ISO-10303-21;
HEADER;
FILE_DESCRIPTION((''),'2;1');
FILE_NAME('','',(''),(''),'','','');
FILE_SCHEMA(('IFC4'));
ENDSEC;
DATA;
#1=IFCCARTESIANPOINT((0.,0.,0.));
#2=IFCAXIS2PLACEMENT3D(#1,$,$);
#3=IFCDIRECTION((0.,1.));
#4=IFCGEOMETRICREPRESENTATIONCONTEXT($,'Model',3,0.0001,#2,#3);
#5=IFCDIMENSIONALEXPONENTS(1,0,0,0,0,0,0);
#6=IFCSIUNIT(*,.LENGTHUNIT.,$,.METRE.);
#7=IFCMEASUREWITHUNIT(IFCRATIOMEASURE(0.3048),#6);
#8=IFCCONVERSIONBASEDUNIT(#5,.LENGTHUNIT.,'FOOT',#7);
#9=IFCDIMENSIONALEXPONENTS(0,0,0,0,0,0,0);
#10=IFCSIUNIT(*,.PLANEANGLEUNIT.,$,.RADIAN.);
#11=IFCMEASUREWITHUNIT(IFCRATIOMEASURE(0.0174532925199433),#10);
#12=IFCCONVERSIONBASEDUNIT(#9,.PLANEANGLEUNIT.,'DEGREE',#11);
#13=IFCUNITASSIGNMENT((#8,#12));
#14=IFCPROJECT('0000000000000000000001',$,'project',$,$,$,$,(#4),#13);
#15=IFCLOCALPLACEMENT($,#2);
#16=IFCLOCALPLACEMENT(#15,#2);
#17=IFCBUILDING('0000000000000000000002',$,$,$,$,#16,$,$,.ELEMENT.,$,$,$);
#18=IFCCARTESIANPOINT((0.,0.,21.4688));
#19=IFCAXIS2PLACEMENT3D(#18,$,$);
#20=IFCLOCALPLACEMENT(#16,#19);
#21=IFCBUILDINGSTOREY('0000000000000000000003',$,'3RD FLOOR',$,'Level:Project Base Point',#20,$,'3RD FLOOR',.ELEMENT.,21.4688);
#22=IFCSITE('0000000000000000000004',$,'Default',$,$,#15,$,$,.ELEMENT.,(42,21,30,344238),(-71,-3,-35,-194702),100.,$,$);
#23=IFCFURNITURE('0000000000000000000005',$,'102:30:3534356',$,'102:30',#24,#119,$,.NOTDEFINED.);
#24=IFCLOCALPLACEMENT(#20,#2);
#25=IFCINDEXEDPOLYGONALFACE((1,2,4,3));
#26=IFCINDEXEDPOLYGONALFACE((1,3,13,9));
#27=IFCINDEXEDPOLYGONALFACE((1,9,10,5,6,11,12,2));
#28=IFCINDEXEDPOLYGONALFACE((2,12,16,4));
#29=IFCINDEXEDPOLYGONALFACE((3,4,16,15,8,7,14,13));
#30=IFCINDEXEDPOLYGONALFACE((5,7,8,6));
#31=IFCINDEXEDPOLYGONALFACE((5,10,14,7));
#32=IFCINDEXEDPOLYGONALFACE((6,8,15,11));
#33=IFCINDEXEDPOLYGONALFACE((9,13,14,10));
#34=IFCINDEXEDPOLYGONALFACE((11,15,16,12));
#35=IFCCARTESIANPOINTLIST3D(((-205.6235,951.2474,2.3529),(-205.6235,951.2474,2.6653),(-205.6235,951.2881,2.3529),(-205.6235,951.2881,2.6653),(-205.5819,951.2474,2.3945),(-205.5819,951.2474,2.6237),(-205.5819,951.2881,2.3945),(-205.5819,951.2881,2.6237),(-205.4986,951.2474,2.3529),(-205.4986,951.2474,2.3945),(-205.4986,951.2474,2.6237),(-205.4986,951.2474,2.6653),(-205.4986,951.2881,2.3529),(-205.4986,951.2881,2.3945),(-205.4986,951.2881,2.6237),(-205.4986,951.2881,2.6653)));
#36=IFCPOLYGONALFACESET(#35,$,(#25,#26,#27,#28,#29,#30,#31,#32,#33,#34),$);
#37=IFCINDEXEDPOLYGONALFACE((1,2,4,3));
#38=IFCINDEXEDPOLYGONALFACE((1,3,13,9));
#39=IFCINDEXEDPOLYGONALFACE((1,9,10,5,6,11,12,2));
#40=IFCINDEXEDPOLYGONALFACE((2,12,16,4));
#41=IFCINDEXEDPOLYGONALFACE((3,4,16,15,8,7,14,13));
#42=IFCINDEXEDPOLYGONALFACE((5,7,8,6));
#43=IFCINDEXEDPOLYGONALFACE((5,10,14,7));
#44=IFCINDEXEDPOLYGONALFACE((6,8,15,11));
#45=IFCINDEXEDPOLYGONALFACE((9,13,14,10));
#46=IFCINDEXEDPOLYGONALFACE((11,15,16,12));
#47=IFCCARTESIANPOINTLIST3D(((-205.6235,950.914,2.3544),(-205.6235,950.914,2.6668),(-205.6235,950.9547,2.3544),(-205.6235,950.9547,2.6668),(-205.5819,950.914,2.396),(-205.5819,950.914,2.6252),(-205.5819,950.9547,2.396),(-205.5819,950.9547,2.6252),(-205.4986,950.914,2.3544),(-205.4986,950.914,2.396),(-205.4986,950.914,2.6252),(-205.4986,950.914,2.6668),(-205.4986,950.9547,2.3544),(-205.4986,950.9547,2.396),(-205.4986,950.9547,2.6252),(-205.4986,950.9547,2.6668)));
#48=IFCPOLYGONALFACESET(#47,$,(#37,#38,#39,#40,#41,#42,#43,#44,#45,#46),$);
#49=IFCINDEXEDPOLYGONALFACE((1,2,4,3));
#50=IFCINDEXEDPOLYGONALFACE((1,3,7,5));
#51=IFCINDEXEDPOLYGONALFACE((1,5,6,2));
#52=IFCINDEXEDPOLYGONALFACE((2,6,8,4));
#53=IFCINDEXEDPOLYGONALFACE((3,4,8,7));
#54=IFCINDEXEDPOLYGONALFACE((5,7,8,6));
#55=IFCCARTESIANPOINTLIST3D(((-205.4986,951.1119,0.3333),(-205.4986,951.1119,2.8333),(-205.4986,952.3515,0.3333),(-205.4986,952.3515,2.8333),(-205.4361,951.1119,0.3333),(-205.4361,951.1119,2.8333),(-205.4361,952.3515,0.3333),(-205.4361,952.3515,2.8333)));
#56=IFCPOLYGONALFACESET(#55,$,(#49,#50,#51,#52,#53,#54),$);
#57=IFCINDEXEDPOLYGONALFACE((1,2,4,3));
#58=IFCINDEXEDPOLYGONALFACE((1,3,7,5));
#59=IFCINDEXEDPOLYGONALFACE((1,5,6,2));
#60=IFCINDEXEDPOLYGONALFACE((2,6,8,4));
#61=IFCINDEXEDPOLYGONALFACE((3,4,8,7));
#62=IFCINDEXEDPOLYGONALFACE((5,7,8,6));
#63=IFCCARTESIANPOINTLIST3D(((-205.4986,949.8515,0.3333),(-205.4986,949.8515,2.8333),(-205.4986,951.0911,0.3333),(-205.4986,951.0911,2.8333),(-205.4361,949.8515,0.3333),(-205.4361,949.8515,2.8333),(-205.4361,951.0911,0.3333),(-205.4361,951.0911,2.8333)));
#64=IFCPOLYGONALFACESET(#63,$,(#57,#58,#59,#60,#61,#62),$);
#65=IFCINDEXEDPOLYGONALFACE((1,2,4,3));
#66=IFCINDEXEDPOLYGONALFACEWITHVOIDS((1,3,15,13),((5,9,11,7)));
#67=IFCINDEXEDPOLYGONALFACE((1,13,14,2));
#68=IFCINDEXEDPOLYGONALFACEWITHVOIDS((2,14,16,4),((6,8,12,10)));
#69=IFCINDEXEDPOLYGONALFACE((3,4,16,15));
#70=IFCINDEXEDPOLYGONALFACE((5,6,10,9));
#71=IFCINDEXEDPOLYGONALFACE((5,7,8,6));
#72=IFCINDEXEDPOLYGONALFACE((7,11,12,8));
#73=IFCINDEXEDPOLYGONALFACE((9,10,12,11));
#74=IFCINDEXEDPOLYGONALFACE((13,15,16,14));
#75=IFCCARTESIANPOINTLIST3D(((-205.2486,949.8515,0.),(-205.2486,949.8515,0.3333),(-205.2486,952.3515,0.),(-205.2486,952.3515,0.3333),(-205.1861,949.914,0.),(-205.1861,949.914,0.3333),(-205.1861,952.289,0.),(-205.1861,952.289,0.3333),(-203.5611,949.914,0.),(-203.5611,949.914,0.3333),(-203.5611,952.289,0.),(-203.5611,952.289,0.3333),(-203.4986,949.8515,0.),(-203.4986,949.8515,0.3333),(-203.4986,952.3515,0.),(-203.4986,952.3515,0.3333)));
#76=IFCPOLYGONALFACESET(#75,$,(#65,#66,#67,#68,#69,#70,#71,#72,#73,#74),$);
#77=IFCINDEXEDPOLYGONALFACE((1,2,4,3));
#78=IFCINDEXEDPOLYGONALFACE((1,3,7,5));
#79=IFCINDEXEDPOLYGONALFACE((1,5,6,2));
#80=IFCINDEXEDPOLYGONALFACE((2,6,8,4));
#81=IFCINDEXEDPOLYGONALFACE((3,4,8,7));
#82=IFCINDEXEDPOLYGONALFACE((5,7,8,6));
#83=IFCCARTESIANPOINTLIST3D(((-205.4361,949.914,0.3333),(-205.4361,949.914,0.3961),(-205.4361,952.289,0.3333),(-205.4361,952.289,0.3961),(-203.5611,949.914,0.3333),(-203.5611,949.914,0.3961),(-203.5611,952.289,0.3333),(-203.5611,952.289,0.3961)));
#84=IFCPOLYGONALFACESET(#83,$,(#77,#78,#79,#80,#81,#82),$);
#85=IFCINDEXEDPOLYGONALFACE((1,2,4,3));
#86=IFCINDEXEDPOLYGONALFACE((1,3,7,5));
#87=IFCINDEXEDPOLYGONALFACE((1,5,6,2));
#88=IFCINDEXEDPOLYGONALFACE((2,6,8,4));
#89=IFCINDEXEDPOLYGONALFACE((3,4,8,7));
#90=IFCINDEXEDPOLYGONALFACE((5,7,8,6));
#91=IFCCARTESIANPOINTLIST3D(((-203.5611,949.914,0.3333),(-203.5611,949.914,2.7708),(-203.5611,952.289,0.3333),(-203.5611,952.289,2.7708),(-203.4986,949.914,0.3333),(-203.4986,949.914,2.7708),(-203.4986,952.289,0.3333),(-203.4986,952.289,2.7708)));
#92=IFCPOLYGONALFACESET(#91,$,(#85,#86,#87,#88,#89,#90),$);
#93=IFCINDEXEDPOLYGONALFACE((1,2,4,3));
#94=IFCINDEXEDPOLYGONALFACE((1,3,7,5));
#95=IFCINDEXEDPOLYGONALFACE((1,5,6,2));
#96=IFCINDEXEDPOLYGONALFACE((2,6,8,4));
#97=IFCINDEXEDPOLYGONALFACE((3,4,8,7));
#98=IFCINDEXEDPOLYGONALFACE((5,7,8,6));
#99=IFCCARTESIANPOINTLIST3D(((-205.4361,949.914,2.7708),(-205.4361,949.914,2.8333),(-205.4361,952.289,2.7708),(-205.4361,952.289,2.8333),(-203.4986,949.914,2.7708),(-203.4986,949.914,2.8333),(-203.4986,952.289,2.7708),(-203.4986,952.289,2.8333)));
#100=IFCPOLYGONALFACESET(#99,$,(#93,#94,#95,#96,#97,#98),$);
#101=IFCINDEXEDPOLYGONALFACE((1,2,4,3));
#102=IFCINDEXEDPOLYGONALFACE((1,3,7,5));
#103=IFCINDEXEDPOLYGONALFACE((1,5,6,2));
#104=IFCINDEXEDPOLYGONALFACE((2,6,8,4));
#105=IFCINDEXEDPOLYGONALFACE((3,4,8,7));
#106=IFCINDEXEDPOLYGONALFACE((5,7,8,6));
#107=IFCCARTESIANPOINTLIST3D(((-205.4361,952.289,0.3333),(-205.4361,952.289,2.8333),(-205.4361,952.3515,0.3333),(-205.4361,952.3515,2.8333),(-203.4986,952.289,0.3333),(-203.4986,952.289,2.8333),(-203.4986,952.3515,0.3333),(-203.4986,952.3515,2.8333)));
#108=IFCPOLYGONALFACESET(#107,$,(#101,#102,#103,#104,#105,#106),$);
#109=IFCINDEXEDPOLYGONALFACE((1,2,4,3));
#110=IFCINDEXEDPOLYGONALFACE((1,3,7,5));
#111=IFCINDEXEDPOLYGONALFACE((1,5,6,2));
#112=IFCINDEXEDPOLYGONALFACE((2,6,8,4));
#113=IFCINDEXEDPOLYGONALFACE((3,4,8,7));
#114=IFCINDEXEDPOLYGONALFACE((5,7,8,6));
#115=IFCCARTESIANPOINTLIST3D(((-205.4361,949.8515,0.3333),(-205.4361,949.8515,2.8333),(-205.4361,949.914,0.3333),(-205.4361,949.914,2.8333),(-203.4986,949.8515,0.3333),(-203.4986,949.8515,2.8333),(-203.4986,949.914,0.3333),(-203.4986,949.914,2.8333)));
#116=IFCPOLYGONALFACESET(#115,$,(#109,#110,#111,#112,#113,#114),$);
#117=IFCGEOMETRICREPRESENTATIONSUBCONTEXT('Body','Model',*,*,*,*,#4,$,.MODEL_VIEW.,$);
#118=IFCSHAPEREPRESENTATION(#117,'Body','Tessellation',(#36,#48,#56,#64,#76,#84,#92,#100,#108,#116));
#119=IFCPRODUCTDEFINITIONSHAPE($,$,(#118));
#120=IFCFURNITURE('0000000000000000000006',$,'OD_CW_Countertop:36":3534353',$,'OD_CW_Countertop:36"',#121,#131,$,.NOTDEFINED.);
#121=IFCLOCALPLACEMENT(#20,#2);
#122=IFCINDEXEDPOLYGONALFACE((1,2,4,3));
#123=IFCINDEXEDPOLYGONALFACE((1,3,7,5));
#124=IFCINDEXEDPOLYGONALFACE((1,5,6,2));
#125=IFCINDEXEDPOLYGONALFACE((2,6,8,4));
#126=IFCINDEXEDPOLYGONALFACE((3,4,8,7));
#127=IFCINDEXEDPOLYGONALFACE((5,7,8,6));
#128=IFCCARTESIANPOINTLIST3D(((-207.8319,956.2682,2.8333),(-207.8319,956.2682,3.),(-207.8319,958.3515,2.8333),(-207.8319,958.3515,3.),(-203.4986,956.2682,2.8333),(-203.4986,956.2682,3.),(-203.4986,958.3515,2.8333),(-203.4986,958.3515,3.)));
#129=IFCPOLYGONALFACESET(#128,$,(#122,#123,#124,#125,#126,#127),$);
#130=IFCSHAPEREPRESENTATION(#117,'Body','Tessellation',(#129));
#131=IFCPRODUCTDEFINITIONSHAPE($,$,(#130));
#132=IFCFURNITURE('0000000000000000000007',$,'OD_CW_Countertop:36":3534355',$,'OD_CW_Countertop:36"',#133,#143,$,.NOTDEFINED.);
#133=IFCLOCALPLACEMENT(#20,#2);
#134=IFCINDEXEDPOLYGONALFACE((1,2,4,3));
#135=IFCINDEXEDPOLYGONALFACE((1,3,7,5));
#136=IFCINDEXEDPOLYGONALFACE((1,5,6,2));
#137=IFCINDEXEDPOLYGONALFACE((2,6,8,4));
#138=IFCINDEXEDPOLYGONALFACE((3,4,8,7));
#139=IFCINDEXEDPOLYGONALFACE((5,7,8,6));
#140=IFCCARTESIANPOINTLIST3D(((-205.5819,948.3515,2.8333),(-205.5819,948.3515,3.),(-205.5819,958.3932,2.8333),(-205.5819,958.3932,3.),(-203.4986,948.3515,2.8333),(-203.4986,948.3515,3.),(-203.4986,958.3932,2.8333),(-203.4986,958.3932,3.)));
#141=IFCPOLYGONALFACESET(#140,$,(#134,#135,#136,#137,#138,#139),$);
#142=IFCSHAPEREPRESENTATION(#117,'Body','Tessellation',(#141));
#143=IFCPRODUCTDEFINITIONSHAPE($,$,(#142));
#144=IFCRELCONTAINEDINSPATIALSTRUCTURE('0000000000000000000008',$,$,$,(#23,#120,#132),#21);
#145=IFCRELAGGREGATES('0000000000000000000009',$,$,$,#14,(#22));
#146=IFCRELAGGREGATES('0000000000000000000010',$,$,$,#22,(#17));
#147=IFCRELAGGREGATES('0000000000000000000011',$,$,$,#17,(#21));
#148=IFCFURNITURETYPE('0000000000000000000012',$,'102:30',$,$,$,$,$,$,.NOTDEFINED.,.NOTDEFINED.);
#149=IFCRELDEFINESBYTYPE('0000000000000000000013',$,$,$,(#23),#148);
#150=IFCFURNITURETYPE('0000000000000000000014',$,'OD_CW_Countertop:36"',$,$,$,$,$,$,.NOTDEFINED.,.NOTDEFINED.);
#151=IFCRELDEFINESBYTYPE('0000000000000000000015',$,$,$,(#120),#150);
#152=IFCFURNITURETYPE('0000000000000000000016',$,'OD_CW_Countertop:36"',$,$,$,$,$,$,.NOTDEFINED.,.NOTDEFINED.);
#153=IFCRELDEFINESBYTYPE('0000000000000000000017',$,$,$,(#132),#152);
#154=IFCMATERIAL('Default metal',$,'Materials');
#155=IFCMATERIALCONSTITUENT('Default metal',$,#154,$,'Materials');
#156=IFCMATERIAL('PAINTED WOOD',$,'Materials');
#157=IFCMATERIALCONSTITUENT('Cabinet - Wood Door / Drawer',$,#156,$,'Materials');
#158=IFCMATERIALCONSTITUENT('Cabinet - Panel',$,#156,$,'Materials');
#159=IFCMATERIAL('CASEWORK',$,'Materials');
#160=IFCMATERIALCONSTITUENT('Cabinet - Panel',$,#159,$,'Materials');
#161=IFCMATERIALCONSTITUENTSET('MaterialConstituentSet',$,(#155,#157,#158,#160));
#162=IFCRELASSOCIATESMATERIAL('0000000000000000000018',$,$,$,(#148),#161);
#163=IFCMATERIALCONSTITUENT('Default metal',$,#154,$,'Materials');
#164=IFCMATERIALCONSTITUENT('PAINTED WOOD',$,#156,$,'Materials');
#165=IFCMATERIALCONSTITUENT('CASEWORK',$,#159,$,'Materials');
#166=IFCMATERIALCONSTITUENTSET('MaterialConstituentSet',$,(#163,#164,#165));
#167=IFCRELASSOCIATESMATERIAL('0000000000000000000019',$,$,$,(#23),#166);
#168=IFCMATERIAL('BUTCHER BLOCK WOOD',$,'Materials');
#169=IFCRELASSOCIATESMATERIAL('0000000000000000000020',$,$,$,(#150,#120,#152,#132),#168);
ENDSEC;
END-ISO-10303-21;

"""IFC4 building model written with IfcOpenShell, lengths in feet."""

from ifc_helpers import new_model, entity, si_unit, converted_unit, direction, frame, frame_2d, origin, origin_2d_with_axis, place, context, subcontext, project, spatial, polyline, rectangle, outline, extrude, source, transform, mapped, material, constituent, constituent_set, type_object, type_shapes, element, save


model = new_model("IFC4")

# Units and contexts
model_context = context("Model", 3, precision=0.0001, world=origin(), true_north=direction((0.0, 1.0)))
body_context = subcontext(model_context, "Body", "Model", "MODEL_VIEW")
ifc_project = project(units=[converted_unit("LENGTHUNIT", "FOOT", entity("IfcRatioMeasure", 0.3048), si_unit("LENGTHUNIT", "METRE"), dimensions=[1, 0, 0, 0, 0, 0, 0]), converted_unit("PLANEANGLEUNIT", "DEGREE", entity("IfcRatioMeasure", 0.0174532925199433), si_unit("PLANEANGLEUNIT", "RADIAN"), dimensions=[0, 0, 0, 0, 0, 0, 0])], contexts=[model_context])

# Site, building, storey
site_placement = place(None, origin())
site = spatial("IfcSite", under=ifc_project, at=site_placement, Name="Default", CompositionType="ELEMENT", RefLatitude=(42, 21, 30, 344238), RefLongitude=(-71, -3, -35, -194702), RefElevation=100.0)
building_placement = place(site_placement, origin())
building = spatial("IfcBuilding", under=site, at=building_placement, CompositionType="ELEMENT")
storey_placement = place(building_placement, frame((0.0, 0.0, 21.4688)))
storey = spatial("IfcBuildingStorey", under=building, at=storey_placement, Name="3RD FLOOR", ObjectType="Level:Project Base Point", LongName="3RD FLOOR", CompositionType="ELEMENT", Elevation=21.4688)

# Furniture
ifc_material_1 = material(Name="CASEWORK", Category="Materials")
ifc_material_2 = material(Name="PAINTED WOOD", Category="Materials")
ifc_material_3 = material(Name="Default metal", Category="Materials")
ifc_constituent_1 = constituent(ifc_material_3, Name="Default metal", Category="Materials")
ifc_constituent_2 = constituent(ifc_material_2, Name="PAINTED WOOD", Category="Materials")
ifc_constituent_3 = constituent(ifc_material_1, Name="CASEWORK", Category="Materials")
ifc_constituent_set_1 = constituent_set(constituents=[ifc_constituent_1, ifc_constituent_2, ifc_constituent_3], Name="MaterialConstituentSet")
ifc_constituent_4 = constituent(ifc_material_3, Name="Default metal", Category="Materials")
ifc_constituent_5 = constituent(ifc_material_2, Name="Cabinet - Wood Door / Drawer", Category="Materials")
ifc_constituent_6 = constituent(ifc_material_2, Name="Cabinet - Panel", Category="Materials")
ifc_constituent_7 = constituent(ifc_material_1, Name="Cabinet - Panel", Category="Materials")
ifc_constituent_set_2 = constituent_set(constituents=[ifc_constituent_4, ifc_constituent_5, ifc_constituent_6, ifc_constituent_7], Name="MaterialConstituentSet")
furniture_type_1 = type_object("IfcFurnitureType", Name="102:30", AssemblyPlace="NOTDEFINED", PredefinedType="NOTDEFINED", material=ifc_constituent_set_2)
shared_shape_1 = source(origin(), body_context, "Body", "SweptSolid", [
    extrude(outline(polyline([(-0.0521, -0.1146), (-0.0521, -0.1562), (0.0729, -0.1562), (0.0729, 0.1562), (-0.0521, 0.1562), (-0.0521, 0.1146), (0.0313, 0.1146), (0.0313, -0.1146), (-0.0521, -0.1146)])), frame((0.2073, 2.0521, 2.5091), z_axis=(-1.0, 0.0, 0.0), x_axis=(0.0, 1.0, 0.0)), (0.0, 0.0, -1.0), 0.0407),
    extrude(outline(polyline([(-0.0521, -0.1146), (-0.0521, -0.1562), (0.0729, -0.1562), (0.0729, 0.1562), (-0.0521, 0.1562), (-0.0521, 0.1146), (0.0313, 0.1146), (0.0313, -0.1146), (-0.0521, -0.1146)])), frame((-0.126, 2.0521, 2.5106), z_axis=(-1.0, 0.0, 0.0), x_axis=(0.0, 1.0, 0.0)), (0.0, 0.0, -1.0), 0.0407),
    extrude(rectangle(XDim=1.2396, YDim=0.0625, at=frame_2d((0.0, 0.0), x_axis=(1.0, 0.0))), frame((0.6917, 1.9688, 0.3333), z_axis=(0.0, 0.0, 1.0), x_axis=(-1.0, 0.0, 0.0)), (0.0, 0.0, 1.0), 2.5),
    extrude(rectangle(XDim=1.2396, YDim=0.0625, at=origin_2d_with_axis()), frame((-0.5687, 1.9688, 0.3333), z_axis=(0.0, 0.0, 1.0), x_axis=(-1.0, 0.0, 0.0)), (0.0, 0.0, 1.0), 2.5),
    extrude(outline(polyline([(-0.875, -1.25), (0.875, -1.25), (0.875, 1.25), (-0.875, 1.25), (-0.875, -1.25)]), holes=[polyline([(-0.8125, -1.1875), (-0.8125, 1.1875), (0.8125, 1.1875), (0.8125, -1.1875), (-0.8125, -1.1875)])]), frame((0.0615, 0.875, 0.0), z_axis=(0.0, 0.0, 1.0), x_axis=(0.0, -1.0, 0.0)), (0.0, 0.0, 1.0), 0.3333),
    extrude(rectangle(XDim=1.875, YDim=2.375, at=origin_2d_with_axis()), frame((0.0615, 1.0, 0.3333), z_axis=(0.0, 0.0, 1.0), x_axis=(0.0, 1.0, 0.0)), (0.0, 0.0, 1.0), 0.0627),
    extrude(rectangle(XDim=2.375, YDim=0.0625, at=origin_2d_with_axis()), frame((0.0615, 0.0312, 0.3333), z_axis=(0.0, 0.0, 1.0), x_axis=(-1.0, 0.0, 0.0)), (0.0, 0.0, 1.0), 2.4375),
    extrude(rectangle(XDim=1.9375, YDim=2.375, at=frame_2d((0.0, 0.0), x_axis=(1.0, 0.0))), frame((0.0615, 0.9688, 2.7708), z_axis=(0.0, 0.0, 1.0), x_axis=(0.0, 1.0, 0.0)), (0.0, 0.0, 1.0), 0.0625),
    extrude(rectangle(XDim=1.9375, YDim=0.0625, at=frame_2d((0.0, 0.0), x_axis=(1.0, 0.0))), frame((1.2802, 0.9687, 0.3333), z_axis=(0.0, 0.0, 1.0), x_axis=(0.0, -1.0, 0.0)), (0.0, 0.0, 1.0), 2.5),
    extrude(rectangle(XDim=1.9375, YDim=0.0625, at=frame_2d((0.0, 0.0), x_axis=(1.0, 0.0))), frame((-1.1573, 0.9687, 0.3333), z_axis=(0.0, 0.0, 1.0), x_axis=(0.0, -1.0, 0.0)), (0.0, 0.0, 1.0), 2.5),
])
type_shapes(furniture_type_1, [shared_shape_1])
furniture_1_placement = place(storey_placement, frame((-203.4986, 951.04, 0.0), z_axis=(0.0, 0.0, 1.0), x_axis=(0.0, 1.0, 0.0)))
element("IfcFurniture", 1, at=furniture_1_placement, inside=storey, type_object=furniture_type_1, material=ifc_constituent_set_1, Name="102:30:3534356", ObjectType="102:30", PredefinedType="NOTDEFINED", context=body_context, shape_type="MappedRepresentation", body=[
    mapped(shared_shape_1, transform((0.0, 0.0, 0.0), scale=1.0)),
])
ifc_material_4 = material(Name="BUTCHER BLOCK WOOD", Category="Materials")
furniture_type_2 = type_object("IfcFurnitureType", Name="OD_CW_Countertop:36\"", AssemblyPlace="NOTDEFINED", PredefinedType="NOTDEFINED", material=ifc_material_4)
shared_shape_2 = source(origin(), body_context, "Body", "SweptSolid", [
    extrude(rectangle(XDim=2.0833, YDim=4.3333, at=frame_2d((0.0, 0.0), x_axis=(1.0, 0.0))), frame((2.1667, 1.0417, 0.0), z_axis=(0.0, 0.0, 1.0), x_axis=(0.0, -1.0, 0.0)), (0.0, 0.0, 1.0), 0.1667),
])
type_shapes(furniture_type_2, [shared_shape_2])
furniture_2_placement = place(storey_placement, frame((-207.8319, 956.2682, 2.8333)))
element("IfcFurniture", 2, at=furniture_2_placement, inside=storey, type_object=furniture_type_2, material=ifc_material_4, Name="OD_CW_Countertop:36\":3534353", ObjectType="OD_CW_Countertop:36\"", PredefinedType="NOTDEFINED", context=body_context, shape_type="MappedRepresentation", body=[
    mapped(shared_shape_2, transform((0.0, 0.0, 0.0), scale=1.0)),
])
furniture_type_3 = type_object("IfcFurnitureType", Name="OD_CW_Countertop:36\"", AssemblyPlace="NOTDEFINED", PredefinedType="NOTDEFINED", material=ifc_material_4)
shared_shape_3 = source(origin(), body_context, "Body", "SweptSolid", [
    extrude(rectangle(XDim=2.0833, YDim=10.0417, at=origin_2d_with_axis()), frame((5.0208, 1.0417, 0.0), z_axis=(0.0, 0.0, 1.0), x_axis=(0.0, -1.0, 0.0)), (0.0, 0.0, 1.0), 0.1667),
])
type_shapes(furniture_type_3, [shared_shape_3])
furniture_3_placement = place(storey_placement, frame((-205.5819, 958.3932, 2.8333), z_axis=(0.0, 0.0, 1.0), x_axis=(0.0, -1.0, 0.0)))
element("IfcFurniture", 3, at=furniture_3_placement, inside=storey, type_object=furniture_type_3, material=ifc_material_4, Name="OD_CW_Countertop:36\":3534355", ObjectType="OD_CW_Countertop:36\"", PredefinedType="NOTDEFINED", context=body_context, shape_type="MappedRepresentation", body=[
    mapped(shared_shape_3, transform((0.0, 0.0, 0.0), scale=1.0)),
])

save(model, "model.ifc")
